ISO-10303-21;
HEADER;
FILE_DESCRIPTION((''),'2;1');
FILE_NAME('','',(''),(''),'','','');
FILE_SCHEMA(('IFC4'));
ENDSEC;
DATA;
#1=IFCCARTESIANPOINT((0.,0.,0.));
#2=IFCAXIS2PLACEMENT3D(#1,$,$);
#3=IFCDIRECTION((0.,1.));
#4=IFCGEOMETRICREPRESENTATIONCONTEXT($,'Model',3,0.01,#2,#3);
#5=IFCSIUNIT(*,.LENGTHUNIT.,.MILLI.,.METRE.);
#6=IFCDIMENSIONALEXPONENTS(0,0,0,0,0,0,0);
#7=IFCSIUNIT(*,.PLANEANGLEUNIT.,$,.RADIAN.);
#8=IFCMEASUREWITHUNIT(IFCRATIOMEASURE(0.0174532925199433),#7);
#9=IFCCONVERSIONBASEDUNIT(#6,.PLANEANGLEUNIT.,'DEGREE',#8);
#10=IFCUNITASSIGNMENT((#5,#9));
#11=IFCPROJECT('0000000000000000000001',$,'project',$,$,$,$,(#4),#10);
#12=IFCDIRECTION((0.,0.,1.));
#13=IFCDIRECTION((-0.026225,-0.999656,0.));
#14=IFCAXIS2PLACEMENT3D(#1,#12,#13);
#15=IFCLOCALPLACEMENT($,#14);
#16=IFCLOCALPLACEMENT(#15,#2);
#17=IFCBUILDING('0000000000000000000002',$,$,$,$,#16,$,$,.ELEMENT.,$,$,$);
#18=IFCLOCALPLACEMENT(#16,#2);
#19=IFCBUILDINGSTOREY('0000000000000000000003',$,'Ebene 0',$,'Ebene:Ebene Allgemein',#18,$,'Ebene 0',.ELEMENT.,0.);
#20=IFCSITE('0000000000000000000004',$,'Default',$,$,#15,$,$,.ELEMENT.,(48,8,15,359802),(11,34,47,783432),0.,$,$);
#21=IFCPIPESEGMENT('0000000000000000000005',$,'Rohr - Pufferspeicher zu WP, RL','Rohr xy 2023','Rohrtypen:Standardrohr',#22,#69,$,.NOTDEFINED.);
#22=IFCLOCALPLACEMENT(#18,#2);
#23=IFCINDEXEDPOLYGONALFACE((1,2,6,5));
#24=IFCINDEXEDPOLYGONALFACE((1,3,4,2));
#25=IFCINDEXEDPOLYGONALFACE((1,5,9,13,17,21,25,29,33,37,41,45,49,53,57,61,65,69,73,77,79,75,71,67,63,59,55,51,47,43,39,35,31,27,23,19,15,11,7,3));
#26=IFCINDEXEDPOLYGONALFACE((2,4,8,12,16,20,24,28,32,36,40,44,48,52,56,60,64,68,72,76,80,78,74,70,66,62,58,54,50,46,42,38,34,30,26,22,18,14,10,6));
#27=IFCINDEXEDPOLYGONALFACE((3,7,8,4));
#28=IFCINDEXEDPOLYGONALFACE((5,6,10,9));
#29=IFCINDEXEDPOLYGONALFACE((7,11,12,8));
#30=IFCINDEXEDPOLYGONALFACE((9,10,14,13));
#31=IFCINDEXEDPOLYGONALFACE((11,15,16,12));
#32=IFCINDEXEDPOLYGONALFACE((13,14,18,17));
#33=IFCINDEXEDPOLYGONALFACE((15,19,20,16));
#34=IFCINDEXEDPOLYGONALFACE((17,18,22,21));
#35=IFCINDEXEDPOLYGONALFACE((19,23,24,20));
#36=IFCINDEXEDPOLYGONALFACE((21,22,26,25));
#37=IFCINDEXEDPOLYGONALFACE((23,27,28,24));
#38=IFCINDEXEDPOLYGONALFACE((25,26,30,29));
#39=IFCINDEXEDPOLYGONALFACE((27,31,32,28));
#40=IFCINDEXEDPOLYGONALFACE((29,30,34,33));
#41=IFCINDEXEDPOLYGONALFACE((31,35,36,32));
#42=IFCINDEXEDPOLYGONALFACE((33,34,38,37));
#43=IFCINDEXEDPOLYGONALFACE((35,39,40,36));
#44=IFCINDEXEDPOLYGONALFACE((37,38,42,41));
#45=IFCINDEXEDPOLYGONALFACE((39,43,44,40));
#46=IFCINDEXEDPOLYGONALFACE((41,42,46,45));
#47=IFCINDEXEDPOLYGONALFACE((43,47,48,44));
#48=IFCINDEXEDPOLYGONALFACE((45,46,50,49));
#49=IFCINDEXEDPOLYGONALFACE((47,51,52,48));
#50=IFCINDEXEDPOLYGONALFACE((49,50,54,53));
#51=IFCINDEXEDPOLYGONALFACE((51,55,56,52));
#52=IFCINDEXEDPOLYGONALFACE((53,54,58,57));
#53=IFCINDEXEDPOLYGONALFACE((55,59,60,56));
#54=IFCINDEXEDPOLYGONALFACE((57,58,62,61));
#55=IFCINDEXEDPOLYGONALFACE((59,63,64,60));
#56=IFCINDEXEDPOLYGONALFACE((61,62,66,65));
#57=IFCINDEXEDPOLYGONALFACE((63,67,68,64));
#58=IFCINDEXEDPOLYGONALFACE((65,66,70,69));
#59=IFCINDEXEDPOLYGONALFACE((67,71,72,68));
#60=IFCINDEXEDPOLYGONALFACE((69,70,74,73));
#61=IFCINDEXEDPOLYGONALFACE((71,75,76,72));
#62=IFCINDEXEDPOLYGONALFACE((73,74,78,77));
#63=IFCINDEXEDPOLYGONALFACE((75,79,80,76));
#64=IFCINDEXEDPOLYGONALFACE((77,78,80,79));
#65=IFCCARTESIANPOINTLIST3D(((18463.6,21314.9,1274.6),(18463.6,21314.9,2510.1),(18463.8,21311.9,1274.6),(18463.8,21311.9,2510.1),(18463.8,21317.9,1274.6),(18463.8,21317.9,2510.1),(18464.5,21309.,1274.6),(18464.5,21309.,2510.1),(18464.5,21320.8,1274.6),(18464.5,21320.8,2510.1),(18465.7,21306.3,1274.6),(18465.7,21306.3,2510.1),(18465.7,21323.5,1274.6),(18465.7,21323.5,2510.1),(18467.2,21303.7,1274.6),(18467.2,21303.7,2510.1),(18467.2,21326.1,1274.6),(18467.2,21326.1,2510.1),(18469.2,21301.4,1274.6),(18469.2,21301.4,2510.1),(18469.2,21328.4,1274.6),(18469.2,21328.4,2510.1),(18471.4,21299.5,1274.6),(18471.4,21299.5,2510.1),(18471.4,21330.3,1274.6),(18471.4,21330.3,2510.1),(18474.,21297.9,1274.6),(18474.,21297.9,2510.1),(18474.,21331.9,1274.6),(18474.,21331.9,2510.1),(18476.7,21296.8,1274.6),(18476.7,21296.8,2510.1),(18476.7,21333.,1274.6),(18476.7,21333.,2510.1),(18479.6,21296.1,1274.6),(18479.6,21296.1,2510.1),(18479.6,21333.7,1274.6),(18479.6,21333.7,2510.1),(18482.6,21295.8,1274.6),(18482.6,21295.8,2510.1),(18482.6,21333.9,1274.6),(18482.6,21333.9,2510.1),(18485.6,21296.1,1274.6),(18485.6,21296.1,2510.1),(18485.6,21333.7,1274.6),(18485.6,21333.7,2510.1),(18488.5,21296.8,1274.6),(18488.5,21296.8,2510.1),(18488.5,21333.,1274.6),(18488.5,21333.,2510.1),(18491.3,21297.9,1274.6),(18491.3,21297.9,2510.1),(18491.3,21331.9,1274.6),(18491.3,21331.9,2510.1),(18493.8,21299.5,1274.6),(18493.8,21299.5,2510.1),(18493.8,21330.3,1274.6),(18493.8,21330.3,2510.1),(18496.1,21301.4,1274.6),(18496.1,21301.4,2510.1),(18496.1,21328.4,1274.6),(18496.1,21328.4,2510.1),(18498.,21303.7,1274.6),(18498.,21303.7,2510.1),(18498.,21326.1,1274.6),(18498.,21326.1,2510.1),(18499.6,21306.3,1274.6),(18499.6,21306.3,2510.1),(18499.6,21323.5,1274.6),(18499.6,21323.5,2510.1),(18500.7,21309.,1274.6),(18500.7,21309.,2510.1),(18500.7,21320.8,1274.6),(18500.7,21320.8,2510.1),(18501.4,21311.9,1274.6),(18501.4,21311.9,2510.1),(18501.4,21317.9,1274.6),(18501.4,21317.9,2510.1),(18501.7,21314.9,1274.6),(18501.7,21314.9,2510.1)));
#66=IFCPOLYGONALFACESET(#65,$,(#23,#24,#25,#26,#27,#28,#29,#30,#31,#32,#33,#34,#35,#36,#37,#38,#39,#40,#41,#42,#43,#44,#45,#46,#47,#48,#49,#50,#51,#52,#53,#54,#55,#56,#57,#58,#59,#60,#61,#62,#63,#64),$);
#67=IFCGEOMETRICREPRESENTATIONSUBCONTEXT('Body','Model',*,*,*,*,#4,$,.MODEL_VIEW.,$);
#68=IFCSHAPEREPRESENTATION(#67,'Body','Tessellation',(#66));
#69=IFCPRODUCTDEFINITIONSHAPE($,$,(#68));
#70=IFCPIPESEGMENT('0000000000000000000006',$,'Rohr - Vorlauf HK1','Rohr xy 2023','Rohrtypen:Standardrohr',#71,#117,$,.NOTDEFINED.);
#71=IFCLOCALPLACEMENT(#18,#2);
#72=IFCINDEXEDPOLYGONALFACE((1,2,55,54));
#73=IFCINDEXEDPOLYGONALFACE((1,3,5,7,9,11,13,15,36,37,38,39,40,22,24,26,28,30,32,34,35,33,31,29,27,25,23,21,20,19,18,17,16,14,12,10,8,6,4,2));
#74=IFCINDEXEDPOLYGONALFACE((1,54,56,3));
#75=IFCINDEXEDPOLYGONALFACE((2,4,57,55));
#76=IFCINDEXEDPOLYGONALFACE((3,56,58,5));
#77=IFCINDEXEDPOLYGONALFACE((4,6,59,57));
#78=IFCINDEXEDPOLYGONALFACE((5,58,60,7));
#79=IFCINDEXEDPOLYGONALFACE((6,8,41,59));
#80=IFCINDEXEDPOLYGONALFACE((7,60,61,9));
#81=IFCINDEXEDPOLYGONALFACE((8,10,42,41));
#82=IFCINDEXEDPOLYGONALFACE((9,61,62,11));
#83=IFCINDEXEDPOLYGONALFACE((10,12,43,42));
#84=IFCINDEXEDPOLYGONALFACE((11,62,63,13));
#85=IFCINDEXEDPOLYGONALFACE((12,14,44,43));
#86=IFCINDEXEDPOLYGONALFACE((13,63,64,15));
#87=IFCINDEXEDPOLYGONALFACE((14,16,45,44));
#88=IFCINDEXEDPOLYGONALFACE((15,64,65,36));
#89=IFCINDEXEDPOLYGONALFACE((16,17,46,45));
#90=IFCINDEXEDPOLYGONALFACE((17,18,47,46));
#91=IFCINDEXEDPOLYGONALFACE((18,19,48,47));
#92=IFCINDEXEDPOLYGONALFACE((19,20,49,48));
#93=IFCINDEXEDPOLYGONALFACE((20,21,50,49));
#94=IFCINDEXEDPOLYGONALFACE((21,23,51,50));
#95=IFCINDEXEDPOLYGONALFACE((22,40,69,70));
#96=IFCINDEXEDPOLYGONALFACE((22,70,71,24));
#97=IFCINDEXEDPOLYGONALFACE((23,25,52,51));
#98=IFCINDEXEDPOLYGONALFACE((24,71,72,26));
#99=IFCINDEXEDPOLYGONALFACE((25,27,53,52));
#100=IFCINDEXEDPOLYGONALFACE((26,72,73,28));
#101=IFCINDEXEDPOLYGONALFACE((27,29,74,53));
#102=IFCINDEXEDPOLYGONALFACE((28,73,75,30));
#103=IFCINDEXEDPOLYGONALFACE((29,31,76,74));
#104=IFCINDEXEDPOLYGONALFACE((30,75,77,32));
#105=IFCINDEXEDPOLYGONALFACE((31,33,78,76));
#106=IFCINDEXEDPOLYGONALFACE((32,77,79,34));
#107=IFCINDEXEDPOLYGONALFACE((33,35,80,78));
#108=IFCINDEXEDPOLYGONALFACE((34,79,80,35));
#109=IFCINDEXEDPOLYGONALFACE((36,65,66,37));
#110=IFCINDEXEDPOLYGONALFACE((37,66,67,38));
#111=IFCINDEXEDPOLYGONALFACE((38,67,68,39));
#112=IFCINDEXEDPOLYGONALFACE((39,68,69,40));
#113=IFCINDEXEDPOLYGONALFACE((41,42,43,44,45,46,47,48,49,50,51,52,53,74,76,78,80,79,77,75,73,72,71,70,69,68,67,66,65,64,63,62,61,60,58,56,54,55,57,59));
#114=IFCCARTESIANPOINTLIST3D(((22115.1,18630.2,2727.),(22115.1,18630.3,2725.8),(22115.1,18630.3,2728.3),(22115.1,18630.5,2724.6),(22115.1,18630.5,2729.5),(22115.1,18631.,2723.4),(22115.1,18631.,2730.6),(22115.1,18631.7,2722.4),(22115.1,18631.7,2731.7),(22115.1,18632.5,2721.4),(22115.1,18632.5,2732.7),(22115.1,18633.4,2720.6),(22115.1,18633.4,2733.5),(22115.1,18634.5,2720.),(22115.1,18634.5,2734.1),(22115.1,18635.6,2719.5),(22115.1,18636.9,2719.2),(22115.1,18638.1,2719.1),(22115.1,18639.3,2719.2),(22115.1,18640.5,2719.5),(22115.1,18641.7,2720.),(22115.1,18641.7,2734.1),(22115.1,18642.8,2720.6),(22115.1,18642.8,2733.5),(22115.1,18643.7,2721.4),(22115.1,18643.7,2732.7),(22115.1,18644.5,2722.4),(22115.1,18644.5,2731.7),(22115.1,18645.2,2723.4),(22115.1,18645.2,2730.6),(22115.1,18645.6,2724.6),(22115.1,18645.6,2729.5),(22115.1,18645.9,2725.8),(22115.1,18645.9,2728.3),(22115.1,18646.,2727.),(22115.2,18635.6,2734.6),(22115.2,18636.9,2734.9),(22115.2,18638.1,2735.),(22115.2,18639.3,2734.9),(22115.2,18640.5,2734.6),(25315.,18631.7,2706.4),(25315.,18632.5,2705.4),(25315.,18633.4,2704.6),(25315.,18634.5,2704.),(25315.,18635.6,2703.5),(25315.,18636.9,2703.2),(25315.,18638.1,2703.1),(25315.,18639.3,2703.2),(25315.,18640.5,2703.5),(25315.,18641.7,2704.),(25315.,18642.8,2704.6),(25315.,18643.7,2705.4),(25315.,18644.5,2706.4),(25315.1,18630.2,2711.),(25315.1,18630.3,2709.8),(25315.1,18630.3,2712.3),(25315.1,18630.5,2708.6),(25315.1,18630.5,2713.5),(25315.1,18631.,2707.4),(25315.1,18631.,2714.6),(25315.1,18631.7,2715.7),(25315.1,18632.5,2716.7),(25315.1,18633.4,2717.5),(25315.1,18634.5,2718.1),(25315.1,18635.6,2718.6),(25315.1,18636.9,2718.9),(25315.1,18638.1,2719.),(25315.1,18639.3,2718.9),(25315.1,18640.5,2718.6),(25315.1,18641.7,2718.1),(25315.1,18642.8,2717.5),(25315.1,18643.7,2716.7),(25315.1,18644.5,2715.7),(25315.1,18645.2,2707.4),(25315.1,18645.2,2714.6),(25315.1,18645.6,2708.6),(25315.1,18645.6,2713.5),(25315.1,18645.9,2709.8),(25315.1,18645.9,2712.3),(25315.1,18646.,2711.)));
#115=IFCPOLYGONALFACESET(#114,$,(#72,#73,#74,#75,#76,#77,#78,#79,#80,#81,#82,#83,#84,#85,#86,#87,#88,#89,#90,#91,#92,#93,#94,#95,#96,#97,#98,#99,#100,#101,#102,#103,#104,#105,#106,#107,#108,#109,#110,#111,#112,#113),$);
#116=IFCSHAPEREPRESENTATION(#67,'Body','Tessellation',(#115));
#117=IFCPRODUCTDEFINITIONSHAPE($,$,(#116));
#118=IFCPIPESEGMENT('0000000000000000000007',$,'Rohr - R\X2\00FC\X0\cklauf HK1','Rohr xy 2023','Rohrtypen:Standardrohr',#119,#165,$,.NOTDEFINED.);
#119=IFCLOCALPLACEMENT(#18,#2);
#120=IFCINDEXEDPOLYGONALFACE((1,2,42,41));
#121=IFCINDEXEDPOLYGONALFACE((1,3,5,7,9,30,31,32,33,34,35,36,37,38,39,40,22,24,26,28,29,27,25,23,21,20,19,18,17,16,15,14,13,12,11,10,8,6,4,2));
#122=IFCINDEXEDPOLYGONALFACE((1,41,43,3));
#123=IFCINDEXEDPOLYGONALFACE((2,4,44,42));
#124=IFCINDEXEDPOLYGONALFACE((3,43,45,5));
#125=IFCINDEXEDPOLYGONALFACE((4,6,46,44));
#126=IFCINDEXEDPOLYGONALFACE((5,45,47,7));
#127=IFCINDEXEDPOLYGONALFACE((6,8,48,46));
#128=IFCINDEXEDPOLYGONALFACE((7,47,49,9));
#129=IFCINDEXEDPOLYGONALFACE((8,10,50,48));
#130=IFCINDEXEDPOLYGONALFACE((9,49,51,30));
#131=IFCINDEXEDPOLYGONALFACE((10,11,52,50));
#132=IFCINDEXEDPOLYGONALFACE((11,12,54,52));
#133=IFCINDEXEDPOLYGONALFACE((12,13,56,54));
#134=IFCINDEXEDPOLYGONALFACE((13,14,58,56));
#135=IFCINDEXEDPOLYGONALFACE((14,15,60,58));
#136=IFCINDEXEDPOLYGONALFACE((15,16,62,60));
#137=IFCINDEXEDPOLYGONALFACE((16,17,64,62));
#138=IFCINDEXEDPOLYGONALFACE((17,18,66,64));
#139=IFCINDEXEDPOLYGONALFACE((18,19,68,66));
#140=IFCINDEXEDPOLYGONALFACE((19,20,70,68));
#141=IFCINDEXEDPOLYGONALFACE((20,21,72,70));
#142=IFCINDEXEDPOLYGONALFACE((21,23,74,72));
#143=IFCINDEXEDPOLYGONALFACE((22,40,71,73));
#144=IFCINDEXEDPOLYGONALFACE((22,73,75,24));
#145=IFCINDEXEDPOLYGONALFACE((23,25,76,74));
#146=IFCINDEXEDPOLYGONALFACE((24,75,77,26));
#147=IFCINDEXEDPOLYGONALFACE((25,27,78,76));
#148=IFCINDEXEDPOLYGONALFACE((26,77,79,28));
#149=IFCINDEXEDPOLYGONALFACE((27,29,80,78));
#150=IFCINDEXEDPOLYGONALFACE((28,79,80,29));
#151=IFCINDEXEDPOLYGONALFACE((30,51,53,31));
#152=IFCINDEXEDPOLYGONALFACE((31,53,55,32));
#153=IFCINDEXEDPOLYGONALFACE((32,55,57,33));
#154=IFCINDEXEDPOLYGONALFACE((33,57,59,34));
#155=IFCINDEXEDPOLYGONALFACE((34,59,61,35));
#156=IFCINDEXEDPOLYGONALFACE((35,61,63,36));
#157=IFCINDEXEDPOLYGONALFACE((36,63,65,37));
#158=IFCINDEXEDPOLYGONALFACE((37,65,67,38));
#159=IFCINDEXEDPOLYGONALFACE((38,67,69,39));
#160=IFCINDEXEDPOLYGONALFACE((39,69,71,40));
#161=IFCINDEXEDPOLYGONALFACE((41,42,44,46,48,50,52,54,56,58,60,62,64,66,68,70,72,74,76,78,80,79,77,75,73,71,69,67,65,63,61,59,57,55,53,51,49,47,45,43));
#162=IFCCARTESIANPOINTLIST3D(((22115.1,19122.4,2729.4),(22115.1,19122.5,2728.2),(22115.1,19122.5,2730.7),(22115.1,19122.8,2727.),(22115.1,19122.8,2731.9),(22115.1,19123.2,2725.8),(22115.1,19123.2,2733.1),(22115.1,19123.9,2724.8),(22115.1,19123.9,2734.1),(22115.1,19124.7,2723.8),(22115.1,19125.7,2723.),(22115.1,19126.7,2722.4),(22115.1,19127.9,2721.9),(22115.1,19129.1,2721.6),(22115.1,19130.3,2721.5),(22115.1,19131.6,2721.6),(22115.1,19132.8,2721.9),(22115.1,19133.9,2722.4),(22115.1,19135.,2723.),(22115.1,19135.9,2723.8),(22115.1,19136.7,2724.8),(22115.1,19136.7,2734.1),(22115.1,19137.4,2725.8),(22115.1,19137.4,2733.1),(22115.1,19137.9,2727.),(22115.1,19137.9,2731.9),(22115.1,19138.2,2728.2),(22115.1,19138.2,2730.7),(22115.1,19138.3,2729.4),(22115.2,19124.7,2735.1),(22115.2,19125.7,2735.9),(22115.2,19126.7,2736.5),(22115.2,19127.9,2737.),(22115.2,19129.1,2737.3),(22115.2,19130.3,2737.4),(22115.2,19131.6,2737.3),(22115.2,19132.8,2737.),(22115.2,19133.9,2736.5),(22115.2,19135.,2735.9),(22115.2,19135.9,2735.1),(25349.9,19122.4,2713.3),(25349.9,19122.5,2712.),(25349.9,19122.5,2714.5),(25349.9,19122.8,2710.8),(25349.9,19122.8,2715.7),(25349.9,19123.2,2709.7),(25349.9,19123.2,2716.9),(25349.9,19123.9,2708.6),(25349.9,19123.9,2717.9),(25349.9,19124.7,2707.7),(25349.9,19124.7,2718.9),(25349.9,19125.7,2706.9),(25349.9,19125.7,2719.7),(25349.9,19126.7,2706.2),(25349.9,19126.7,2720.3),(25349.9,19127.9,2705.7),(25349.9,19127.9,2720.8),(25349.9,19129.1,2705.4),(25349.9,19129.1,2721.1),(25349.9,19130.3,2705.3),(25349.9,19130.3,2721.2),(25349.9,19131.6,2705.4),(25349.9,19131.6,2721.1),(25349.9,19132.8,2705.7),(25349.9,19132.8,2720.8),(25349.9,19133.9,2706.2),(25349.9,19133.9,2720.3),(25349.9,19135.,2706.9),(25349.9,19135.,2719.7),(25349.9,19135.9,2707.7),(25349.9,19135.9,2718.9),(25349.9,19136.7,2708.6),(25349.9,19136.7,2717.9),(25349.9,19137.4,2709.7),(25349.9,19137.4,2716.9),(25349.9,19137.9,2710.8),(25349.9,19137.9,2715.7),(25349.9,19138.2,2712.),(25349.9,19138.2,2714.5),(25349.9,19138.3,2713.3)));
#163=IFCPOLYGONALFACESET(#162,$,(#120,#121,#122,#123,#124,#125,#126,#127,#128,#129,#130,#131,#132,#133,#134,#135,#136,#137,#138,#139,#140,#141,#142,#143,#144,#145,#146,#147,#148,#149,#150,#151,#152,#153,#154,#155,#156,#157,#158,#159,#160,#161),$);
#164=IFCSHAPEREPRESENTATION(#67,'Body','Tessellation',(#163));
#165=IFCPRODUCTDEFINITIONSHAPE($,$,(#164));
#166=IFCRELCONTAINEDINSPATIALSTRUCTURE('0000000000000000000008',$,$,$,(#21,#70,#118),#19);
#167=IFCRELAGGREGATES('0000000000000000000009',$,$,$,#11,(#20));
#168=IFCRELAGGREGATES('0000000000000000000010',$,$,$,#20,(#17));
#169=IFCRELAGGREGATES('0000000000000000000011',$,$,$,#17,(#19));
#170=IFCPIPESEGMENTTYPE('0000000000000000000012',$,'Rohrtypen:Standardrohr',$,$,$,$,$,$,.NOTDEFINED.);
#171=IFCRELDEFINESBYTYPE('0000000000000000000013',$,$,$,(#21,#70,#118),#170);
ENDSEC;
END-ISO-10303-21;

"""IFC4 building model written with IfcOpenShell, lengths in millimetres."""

from ifc_helpers import new_model, entity, si_unit, converted_unit, direction, frame, origin, place, context, subcontext, project, spatial, indexed_curve, outline, extrude, type_object, element, save


model = new_model("IFC4")

# Units and contexts
model_context = context("Model", 3, precision=0.01, world=origin(), true_north=direction((0.0, 1.0)))
body_context = subcontext(model_context, "Body", "Model", "MODEL_VIEW")
ifc_project = project(units=[si_unit("LENGTHUNIT", "METRE", prefix="MILLI"), converted_unit("PLANEANGLEUNIT", "DEGREE", entity("IfcRatioMeasure", 0.0174532925199433), si_unit("PLANEANGLEUNIT", "RADIAN"), dimensions=[0, 0, 0, 0, 0, 0, 0])], contexts=[model_context])

# Site, building, storey
site_placement = place(None, frame((0.0, 0.0, 0.0), z_axis=(0.0, 0.0, 1.0), x_axis=(-0.026225, -0.999656, 0.0)))
site = spatial("IfcSite", under=ifc_project, at=site_placement, Name="Default", CompositionType="ELEMENT", RefLatitude=(48, 8, 15, 359802), RefLongitude=(11, 34, 47, 783432), RefElevation=0.0)
building_placement = place(site_placement, origin())
building = spatial("IfcBuilding", under=site, at=building_placement, CompositionType="ELEMENT")
storey_placement = place(building_placement, origin())
storey = spatial("IfcBuildingStorey", under=building, at=storey_placement, Name="Ebene 0", ObjectType="Ebene:Ebene Allgemein", LongName="Ebene 0", CompositionType="ELEMENT", Elevation=0.0)

# Pipe segments
pipe_segment_type = type_object("IfcPipeSegmentType", Name="Rohrtypen:Standardrohr", PredefinedType="NOTDEFINED")
pipe_segment_1_placement = place(storey_placement, origin())
element("IfcPipeSegment", 1, at=pipe_segment_1_placement, inside=storey, type_object=pipe_segment_type, Name="Rohr - Pufferspeicher zu WP, RL", Description="Rohr xy 2023", ObjectType="Rohrtypen:Standardrohr", PredefinedType="NOTDEFINED", context=body_context, shape_type="SweptSolid", body=[
    extrude(outline(indexed_curve([(19.1, 0.0), (18.8, 3.0), (18.1, 5.9), (17.0, 8.6), (15.4, 11.2), (13.5, 13.5), (11.2, 15.4), (8.6, 17.0), (5.9, 18.1), (3.0, 18.8), (0.0, 19.1), (-3.0, 18.8), (-5.9, 18.1), (-8.6, 17.0), (-11.2, 15.4), (-13.5, 13.5), (-15.4, 11.2), (-17.0, 8.6), (-18.1, 5.9), (-18.8, 3.0), (-19.1, 0.0), (-18.8, -3.0), (-18.1, -5.9), (-17.0, -8.6), (-15.4, -11.2), (-13.5, -13.5), (-11.2, -15.4), (-8.6, -17.0), (-5.9, -18.1), (-3.0, -18.8), (0.0, -19.1), (3.0, -18.8), (5.9, -18.1), (8.6, -17.0), (11.2, -15.4), (13.5, -13.5), (15.4, -11.2), (17.0, -8.6), (18.1, -5.9), (18.8, -3.0), (19.1, 0.0)], self_intersect=False)), frame((18482.6, 21314.9, 1274.6), z_axis=(0.0, 0.0, 1.0), x_axis=(-1.0, 0.0, 0.0)), (0.0, 0.0, 1.0), 1235.5),
])
pipe_segment_2_placement = place(storey_placement, origin())
element("IfcPipeSegment", 2, at=pipe_segment_2_placement, inside=storey, type_object=pipe_segment_type, Name="Rohr - Vorlauf HK1", Description="Rohr xy 2023", ObjectType="Rohrtypen:Standardrohr", PredefinedType="NOTDEFINED", context=body_context, shape_type="SweptSolid", body=[
    extrude(outline(indexed_curve([(7.9, 0.0), (7.8, 1.2), (7.6, 2.5), (7.1, 3.6), (6.4, 4.7), (5.6, 5.6), (4.7, 6.4), (3.6, 7.1), (2.5, 7.6), (1.2, 7.8), (0.0, 7.9), (-1.2, 7.8), (-2.5, 7.6), (-3.6, 7.1), (-4.7, 6.4), (-5.6, 5.6), (-6.4, 4.7), (-7.1, 3.6), (-7.6, 2.5), (-7.8, 1.2), (-7.9, 0.0), (-7.8, -1.2), (-7.6, -2.5), (-7.1, -3.6), (-6.4, -4.7), (-5.6, -5.6), (-4.7, -6.4), (-3.6, -7.1), (-2.5, -7.6), (-1.2, -7.8), (0.0, -7.9), (1.2, -7.8), (2.5, -7.6), (3.6, -7.1), (4.7, -6.4), (5.6, -5.6), (6.4, -4.7), (7.1, -3.6), (7.6, -2.5), (7.8, -1.2), (7.9, 0.0)], self_intersect=False)), frame((25315.1, 18638.1, 2711.0), z_axis=(-0.999988, 0.0, 0.005), x_axis=(0.0, 1.0, 0.0)), (0.0, 0.0, 1.0), 3200.0),
])
pipe_segment_3_placement = place(storey_placement, origin())
element("IfcPipeSegment", 3, at=pipe_segment_3_placement, inside=storey, type_object=pipe_segment_type, Name="Rohr - Rücklauf HK1", Description="Rohr xy 2023", ObjectType="Rohrtypen:Standardrohr", PredefinedType="NOTDEFINED", context=body_context, shape_type="SweptSolid", body=[
    extrude(outline(indexed_curve([(7.9, 0.0), (7.8, 1.2), (7.6, 2.5), (7.1, 3.6), (6.4, 4.7), (5.6, 5.6), (4.7, 6.4), (3.6, 7.1), (2.5, 7.6), (1.2, 7.8), (0.0, 7.9), (-1.2, 7.8), (-2.5, 7.6), (-3.6, 7.1), (-4.7, 6.4), (-5.6, 5.6), (-6.4, 4.7), (-7.1, 3.6), (-7.6, 2.5), (-7.8, 1.2), (-7.9, 0.0), (-7.8, -1.2), (-7.6, -2.5), (-7.1, -3.6), (-6.4, -4.7), (-5.6, -5.6), (-4.7, -6.4), (-3.6, -7.1), (-2.5, -7.6), (-1.2, -7.8), (0.0, -7.9), (1.2, -7.8), (2.5, -7.6), (3.6, -7.1), (4.7, -6.4), (5.6, -5.6), (6.4, -4.7), (7.1, -3.6), (7.6, -2.5), (7.8, -1.2), (7.9, 0.0)], self_intersect=False)), frame((25349.9, 19130.3, 2713.3), z_axis=(-0.999988, 0.0, 0.005), x_axis=(0.0, 1.0, 0.0)), (0.0, 0.0, 1.0), 3234.8),
])

save(model, "model.ifc")
